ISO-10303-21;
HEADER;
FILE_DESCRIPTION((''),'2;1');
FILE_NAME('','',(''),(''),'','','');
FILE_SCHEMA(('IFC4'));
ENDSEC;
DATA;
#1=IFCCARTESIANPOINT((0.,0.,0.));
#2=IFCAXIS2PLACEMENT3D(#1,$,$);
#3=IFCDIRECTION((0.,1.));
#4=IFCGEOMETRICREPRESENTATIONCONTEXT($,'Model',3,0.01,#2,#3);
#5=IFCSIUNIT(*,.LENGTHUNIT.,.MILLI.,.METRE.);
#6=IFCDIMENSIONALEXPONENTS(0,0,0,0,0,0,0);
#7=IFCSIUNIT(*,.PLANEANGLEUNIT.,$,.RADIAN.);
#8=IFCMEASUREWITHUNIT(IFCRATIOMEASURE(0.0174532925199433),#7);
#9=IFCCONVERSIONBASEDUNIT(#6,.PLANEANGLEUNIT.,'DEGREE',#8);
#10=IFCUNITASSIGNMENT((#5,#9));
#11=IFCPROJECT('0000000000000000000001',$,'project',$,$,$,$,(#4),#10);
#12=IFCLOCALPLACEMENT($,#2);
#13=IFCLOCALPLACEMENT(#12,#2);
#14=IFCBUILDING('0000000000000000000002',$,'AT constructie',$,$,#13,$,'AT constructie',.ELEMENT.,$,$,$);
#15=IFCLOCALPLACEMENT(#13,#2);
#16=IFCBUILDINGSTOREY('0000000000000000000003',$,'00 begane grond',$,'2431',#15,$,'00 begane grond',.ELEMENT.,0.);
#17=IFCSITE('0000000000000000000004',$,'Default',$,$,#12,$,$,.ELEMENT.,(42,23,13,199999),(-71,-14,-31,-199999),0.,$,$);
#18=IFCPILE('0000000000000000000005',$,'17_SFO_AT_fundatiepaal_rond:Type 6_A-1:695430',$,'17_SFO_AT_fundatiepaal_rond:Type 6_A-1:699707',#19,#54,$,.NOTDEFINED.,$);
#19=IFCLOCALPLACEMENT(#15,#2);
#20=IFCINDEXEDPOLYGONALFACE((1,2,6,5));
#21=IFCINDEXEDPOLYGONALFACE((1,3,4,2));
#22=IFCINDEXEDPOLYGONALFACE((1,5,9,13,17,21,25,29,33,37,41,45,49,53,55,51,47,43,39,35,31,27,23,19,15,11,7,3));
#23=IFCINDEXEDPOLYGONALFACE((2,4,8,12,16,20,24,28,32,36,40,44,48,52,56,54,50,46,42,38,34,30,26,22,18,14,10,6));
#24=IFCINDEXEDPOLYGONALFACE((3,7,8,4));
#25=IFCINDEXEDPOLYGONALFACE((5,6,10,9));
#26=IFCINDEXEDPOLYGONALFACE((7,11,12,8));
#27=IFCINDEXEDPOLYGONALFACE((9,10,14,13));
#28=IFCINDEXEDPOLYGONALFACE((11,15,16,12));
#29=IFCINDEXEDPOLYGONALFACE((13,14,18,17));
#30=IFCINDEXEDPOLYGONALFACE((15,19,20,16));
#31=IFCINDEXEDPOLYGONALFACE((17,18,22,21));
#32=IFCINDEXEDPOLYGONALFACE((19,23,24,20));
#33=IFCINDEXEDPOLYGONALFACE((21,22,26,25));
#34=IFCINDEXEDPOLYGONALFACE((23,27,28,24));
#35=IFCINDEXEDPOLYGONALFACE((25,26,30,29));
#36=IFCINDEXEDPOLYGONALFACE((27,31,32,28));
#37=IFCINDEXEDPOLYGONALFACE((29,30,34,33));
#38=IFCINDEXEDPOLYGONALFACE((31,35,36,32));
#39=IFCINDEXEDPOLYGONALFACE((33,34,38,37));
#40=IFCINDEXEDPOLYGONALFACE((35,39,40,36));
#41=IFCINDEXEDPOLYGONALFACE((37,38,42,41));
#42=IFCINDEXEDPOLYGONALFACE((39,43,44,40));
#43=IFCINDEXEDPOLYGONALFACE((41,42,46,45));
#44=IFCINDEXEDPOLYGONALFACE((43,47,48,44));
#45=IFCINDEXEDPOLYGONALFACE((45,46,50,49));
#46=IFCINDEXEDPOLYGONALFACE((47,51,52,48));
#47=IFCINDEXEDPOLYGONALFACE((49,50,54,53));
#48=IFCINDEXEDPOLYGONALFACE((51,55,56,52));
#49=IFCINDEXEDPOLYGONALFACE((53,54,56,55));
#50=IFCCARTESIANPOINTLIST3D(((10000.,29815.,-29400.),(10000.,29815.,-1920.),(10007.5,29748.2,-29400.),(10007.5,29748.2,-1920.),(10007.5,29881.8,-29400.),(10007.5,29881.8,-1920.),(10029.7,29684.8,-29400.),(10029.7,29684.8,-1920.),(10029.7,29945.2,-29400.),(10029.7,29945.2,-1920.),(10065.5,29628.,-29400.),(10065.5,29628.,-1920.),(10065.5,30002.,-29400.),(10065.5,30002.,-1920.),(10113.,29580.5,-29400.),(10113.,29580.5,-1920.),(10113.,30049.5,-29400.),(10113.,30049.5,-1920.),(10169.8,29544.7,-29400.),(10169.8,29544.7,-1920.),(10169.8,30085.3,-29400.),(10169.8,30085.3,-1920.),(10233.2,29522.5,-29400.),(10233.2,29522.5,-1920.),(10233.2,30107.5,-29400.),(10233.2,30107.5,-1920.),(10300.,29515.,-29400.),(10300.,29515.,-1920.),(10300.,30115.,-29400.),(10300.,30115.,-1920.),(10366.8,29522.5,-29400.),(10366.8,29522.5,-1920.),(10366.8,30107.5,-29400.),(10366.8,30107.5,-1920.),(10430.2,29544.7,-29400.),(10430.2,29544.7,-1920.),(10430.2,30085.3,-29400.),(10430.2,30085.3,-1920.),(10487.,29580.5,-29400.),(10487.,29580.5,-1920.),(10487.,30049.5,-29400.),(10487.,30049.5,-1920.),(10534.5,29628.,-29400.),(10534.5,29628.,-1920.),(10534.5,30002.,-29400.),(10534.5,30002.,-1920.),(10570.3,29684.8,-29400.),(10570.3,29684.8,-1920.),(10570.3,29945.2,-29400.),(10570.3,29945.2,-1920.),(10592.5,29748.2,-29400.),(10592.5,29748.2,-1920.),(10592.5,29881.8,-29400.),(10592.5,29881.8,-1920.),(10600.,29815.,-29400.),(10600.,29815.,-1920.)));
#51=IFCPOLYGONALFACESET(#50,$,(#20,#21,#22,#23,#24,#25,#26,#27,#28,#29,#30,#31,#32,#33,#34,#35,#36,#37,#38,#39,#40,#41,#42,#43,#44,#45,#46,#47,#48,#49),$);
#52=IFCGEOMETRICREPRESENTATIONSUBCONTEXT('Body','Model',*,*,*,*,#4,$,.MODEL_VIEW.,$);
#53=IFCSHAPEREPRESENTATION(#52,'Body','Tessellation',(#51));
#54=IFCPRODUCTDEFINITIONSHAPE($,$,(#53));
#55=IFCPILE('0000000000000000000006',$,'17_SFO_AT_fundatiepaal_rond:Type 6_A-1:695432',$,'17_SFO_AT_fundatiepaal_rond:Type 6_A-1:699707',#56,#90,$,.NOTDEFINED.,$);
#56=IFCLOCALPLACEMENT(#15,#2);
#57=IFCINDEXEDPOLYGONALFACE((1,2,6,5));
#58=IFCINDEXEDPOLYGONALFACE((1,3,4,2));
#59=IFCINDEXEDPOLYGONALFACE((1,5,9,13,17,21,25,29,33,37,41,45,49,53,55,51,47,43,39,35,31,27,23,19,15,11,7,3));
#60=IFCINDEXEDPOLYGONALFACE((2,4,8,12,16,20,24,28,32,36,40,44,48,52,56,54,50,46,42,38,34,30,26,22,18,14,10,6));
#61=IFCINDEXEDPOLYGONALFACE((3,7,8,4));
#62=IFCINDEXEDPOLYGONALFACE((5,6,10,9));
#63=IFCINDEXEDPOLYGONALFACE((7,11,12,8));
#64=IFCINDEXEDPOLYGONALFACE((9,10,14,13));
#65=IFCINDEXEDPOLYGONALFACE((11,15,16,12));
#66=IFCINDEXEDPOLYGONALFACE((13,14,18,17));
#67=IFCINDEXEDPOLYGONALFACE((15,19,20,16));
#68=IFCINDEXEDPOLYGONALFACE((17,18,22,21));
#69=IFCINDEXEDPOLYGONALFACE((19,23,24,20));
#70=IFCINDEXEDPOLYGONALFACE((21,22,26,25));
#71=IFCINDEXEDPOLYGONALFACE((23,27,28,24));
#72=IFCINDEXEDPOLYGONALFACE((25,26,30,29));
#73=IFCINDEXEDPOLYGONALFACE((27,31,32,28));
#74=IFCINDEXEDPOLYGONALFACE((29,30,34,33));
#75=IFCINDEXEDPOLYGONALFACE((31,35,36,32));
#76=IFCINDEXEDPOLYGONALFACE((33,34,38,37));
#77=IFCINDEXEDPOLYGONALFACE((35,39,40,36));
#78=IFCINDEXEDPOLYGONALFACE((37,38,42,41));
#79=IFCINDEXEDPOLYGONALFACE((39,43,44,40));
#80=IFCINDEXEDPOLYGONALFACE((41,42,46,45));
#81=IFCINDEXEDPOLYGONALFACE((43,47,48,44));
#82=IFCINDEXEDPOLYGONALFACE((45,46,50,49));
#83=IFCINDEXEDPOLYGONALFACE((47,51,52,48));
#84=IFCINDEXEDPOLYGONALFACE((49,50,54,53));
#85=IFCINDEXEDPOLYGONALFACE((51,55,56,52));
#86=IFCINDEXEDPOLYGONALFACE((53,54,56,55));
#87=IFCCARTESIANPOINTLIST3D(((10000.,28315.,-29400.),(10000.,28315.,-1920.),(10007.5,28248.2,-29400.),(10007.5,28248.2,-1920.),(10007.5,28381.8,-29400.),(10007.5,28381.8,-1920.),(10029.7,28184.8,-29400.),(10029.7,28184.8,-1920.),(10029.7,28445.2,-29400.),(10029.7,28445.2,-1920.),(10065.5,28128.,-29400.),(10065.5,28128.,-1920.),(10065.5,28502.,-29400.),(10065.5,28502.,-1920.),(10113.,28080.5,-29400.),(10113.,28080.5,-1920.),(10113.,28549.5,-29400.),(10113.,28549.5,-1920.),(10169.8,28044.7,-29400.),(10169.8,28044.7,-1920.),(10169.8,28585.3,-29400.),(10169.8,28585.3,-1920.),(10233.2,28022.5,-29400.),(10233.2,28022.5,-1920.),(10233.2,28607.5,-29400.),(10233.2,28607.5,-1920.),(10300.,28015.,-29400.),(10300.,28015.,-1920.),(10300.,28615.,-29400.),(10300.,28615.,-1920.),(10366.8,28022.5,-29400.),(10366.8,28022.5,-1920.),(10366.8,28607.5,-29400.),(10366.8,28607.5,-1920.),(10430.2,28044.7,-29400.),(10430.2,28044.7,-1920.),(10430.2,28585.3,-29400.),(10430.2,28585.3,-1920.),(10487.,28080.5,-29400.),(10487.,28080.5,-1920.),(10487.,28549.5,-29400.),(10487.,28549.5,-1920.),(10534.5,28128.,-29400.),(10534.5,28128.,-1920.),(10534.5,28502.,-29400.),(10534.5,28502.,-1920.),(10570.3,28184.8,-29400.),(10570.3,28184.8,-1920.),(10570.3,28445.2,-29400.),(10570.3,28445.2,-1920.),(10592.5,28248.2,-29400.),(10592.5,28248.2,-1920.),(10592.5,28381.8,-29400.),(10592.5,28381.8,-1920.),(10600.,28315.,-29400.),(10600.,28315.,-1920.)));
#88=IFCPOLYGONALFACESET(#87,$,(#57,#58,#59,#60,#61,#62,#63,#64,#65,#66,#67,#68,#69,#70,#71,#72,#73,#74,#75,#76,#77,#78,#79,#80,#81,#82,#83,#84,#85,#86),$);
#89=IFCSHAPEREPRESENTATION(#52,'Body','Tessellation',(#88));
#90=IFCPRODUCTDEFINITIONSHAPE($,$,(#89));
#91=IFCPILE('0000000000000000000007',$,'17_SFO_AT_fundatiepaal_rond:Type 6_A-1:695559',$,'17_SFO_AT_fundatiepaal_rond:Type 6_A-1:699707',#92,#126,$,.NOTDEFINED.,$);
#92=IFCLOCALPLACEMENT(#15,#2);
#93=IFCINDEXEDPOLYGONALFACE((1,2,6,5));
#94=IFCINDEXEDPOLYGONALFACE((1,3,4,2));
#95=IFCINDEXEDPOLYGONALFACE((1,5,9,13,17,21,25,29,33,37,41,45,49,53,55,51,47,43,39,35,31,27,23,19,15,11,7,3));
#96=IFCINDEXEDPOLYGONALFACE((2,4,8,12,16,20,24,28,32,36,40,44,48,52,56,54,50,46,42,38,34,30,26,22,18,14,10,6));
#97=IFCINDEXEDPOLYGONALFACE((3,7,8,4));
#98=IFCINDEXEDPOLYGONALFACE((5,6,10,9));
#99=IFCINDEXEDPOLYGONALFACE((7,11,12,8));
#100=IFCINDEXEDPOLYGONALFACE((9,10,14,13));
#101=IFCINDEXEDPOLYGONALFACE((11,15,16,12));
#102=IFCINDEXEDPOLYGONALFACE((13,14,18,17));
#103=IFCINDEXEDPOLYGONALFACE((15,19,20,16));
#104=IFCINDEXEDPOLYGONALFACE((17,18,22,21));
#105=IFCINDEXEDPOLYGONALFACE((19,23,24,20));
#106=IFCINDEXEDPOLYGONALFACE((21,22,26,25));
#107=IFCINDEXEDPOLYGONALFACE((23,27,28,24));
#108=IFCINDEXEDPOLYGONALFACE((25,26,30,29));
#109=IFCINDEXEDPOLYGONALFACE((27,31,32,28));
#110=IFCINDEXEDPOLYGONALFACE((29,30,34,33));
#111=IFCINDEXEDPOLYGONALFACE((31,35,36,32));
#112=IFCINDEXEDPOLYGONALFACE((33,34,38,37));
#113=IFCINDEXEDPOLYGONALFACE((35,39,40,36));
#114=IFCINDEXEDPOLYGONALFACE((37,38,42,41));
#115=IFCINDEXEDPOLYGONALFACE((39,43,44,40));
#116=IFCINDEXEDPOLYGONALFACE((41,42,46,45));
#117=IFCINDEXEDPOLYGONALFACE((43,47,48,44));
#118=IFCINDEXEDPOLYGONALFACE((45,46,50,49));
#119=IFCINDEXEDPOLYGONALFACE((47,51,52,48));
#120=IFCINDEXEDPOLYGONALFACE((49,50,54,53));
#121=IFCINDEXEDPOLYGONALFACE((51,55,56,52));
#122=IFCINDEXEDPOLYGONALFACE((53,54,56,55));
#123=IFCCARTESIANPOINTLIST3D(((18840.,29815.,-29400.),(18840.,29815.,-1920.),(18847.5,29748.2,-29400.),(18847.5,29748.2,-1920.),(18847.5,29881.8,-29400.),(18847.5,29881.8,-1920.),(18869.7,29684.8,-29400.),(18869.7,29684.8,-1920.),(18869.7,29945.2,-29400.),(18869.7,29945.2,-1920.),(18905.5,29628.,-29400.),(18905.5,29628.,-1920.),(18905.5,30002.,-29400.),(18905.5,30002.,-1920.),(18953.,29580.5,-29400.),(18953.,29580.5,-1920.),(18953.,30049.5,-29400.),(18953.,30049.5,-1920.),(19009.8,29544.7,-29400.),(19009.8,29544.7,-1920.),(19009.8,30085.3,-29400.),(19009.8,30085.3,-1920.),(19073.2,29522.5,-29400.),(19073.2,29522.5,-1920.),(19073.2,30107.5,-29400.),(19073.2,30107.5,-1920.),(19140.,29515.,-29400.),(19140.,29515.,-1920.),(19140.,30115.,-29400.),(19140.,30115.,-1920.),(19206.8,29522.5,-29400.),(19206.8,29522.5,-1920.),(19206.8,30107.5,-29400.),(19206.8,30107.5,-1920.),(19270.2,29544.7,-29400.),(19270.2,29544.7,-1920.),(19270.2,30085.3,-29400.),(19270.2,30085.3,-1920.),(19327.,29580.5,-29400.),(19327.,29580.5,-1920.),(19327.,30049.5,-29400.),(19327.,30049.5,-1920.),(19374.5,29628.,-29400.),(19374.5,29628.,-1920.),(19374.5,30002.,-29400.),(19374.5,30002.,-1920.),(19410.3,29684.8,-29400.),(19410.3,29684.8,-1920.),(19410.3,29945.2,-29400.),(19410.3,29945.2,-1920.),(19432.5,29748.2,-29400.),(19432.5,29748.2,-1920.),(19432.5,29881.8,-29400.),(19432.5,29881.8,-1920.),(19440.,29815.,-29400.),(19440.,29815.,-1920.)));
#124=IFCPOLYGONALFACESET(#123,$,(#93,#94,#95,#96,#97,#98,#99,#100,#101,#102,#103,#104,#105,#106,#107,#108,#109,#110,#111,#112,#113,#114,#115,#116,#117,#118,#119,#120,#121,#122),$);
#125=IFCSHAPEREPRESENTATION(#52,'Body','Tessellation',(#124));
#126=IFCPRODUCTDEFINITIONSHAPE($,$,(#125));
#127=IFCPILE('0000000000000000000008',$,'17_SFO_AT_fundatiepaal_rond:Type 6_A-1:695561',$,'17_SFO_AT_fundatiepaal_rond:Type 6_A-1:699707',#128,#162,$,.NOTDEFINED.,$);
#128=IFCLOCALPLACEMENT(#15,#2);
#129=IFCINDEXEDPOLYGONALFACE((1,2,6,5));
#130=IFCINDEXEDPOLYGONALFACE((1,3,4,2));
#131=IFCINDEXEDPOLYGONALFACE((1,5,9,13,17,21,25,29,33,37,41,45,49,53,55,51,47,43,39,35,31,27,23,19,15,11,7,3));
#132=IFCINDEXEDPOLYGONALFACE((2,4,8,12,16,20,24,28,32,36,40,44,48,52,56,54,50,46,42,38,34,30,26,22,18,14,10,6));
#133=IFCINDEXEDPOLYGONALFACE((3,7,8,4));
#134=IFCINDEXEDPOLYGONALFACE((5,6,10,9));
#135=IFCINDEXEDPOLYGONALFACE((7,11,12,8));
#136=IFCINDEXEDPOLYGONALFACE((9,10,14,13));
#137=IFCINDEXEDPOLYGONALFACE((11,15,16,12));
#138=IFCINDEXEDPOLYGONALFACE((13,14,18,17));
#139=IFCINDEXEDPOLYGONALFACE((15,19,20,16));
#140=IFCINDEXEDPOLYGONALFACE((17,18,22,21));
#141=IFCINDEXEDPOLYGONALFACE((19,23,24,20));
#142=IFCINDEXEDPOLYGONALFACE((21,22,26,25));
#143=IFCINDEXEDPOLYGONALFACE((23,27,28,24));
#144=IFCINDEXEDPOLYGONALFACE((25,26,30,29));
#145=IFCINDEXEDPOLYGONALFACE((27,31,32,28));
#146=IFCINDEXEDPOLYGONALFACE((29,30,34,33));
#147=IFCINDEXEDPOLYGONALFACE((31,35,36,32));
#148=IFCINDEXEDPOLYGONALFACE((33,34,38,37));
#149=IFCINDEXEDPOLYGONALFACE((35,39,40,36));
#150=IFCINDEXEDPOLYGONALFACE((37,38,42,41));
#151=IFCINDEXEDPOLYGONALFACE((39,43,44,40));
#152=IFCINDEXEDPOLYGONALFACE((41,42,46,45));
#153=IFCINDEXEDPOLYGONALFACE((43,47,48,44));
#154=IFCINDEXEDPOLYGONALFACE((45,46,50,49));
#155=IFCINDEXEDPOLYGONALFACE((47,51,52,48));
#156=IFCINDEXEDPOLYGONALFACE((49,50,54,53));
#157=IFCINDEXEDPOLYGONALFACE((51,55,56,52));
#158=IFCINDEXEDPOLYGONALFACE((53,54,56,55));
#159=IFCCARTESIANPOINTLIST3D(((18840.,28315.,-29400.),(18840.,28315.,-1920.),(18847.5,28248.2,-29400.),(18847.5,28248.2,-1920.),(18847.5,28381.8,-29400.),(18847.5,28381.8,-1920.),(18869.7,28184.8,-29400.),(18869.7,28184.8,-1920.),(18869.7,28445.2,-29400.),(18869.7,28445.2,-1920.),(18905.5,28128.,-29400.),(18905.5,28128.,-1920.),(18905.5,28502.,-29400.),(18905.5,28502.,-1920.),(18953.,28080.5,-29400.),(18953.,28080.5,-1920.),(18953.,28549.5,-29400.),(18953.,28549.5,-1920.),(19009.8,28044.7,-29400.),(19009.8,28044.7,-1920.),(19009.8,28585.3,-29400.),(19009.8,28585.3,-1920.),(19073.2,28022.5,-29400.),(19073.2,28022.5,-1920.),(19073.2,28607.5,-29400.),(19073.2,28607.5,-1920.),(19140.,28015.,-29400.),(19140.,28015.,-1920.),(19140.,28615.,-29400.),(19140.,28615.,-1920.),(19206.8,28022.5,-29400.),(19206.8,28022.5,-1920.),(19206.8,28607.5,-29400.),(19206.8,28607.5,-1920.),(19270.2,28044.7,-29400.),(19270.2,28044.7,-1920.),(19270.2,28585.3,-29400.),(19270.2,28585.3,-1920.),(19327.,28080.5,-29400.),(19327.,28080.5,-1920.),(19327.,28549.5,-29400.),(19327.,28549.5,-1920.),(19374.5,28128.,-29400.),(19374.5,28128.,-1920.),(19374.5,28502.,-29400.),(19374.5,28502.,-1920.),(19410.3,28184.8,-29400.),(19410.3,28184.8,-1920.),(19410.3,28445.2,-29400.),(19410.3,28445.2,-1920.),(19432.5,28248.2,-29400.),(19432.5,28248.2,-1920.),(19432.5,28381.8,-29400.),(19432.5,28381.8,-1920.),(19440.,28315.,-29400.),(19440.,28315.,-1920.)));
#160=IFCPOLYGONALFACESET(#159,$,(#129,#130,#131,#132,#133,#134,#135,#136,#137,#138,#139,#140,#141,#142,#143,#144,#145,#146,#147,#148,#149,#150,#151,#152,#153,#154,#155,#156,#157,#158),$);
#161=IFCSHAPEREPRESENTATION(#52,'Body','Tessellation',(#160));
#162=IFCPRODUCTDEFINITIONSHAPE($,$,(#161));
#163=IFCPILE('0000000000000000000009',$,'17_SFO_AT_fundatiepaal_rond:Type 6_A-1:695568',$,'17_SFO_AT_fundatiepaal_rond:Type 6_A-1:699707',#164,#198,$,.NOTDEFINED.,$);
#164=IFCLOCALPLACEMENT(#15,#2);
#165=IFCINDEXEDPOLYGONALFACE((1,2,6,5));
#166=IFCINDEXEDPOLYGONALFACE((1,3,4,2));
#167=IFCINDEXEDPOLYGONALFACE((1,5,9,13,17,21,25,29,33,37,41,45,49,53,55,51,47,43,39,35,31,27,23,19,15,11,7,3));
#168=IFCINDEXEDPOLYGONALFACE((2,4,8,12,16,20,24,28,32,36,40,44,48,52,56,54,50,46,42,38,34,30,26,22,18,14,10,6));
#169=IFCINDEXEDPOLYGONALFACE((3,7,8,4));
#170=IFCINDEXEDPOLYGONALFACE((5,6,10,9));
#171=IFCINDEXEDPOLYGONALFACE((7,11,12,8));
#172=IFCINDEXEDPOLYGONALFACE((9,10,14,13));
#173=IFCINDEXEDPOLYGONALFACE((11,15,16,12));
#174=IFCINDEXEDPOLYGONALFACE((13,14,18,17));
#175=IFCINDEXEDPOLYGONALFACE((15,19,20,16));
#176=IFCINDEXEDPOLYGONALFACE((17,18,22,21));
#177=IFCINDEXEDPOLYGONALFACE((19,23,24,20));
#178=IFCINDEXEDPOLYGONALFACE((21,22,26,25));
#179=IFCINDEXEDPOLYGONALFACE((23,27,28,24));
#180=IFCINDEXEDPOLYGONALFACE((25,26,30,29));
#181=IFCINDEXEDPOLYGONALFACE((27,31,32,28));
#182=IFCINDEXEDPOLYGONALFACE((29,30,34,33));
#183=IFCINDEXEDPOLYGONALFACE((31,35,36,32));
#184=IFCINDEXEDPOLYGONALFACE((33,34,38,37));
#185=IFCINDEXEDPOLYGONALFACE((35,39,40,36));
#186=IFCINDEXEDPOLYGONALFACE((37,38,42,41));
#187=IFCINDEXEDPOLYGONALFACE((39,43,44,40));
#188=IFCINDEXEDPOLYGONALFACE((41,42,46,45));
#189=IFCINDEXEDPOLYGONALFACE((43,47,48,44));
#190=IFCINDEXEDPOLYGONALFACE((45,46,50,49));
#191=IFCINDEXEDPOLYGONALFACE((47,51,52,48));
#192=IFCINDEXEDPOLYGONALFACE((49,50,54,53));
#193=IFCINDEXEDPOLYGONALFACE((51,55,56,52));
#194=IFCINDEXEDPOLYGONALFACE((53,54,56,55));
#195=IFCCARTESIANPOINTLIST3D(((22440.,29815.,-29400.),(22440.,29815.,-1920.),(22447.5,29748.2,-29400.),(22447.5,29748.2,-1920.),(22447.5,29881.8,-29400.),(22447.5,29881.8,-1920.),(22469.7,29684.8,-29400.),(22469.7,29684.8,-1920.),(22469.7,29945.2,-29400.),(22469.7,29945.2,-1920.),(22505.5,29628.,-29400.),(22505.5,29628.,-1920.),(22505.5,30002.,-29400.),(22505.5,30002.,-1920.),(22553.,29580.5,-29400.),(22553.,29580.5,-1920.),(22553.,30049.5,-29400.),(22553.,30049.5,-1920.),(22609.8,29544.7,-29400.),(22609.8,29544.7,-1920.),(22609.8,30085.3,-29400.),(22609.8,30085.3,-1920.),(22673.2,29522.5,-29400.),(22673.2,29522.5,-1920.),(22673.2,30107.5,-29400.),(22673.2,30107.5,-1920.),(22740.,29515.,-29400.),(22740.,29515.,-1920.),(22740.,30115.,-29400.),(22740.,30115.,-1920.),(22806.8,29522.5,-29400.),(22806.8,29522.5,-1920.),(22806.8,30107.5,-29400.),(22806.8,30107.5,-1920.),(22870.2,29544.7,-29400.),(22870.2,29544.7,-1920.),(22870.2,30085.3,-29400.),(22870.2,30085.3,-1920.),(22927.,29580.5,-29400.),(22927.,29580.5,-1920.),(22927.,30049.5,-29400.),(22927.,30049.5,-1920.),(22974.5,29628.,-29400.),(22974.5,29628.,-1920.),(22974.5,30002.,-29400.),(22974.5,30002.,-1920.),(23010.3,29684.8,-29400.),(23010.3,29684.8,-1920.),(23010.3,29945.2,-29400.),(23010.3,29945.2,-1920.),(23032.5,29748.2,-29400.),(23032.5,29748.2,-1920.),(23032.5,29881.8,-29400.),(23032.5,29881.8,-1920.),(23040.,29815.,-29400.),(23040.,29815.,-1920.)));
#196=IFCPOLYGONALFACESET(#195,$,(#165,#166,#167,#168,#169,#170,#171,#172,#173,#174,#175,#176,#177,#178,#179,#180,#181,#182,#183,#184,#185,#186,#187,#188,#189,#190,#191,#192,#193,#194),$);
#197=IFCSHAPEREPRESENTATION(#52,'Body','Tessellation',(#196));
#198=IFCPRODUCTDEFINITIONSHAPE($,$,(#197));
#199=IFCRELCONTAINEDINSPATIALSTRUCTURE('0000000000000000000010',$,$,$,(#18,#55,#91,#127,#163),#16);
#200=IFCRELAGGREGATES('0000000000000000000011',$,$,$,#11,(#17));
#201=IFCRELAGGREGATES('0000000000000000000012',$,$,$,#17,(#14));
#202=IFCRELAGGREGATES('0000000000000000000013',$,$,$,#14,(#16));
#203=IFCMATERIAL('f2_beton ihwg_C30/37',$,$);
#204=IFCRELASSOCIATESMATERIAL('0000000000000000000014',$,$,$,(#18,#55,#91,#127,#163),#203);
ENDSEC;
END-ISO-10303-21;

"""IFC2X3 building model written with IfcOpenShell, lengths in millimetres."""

from ifc_helpers import new_model, entity, si_unit, converted_unit, direction, frame, origin, origin_2d_with_axis, place, context, subcontext, project, spatial, circle, extrude, material, element, save


model = new_model("IFC2X3")

# Units and contexts
model_context = context("Model", 3, precision=0.01, world=origin(), true_north=direction((0.0, 1.0)))
body_context = subcontext(model_context, "Body", "Model", "MODEL_VIEW")
ifc_project = project(units=[si_unit("LENGTHUNIT", "METRE", prefix="MILLI"), converted_unit("PLANEANGLEUNIT", "DEGREE", entity("IfcRatioMeasure", 0.0174532925199433), si_unit("PLANEANGLEUNIT", "RADIAN"), dimensions=[0, 0, 0, 0, 0, 0, 0])], contexts=[model_context])

# Site, building, storey
site_placement = place(None, origin())
site = spatial("IfcSite", under=ifc_project, at=site_placement, Name="Default", CompositionType="ELEMENT", RefLatitude=(42, 23, 13, 199999), RefLongitude=(-71, -14, -31, -199999), RefElevation=0.0)
building_placement = place(site_placement, origin())
building = spatial("IfcBuilding", under=site, at=building_placement, Name="AT constructie", LongName="AT constructie", CompositionType="ELEMENT")
storey_placement = place(building_placement, origin())
storey = spatial("IfcBuildingStorey", under=building, at=storey_placement, Name="00 begane grond", ObjectType="2431", LongName="00 begane grond", CompositionType="ELEMENT", Elevation=0.0)

# Piles
ifc_material = material(Name="f2_beton ihwg_C30/37")
pile_1_placement = place(storey_placement, origin())
element("IfcPile", 1, at=pile_1_placement, inside=storey, material=ifc_material, Name="17_SFO_AT_fundatiepaal_rond:Type 6_A-1:695430", ObjectType="17_SFO_AT_fundatiepaal_rond:Type 6_A-1:699707", PredefinedType="NOTDEFINED", context=body_context, shape_type="SweptSolid", body=[
    extrude(circle(Radius=300.0, at=origin_2d_with_axis()), frame((10300.0, 29815.0, -29400.0)), (0.0, 0.0, 1.0), 27480.0),
])
pile_2_placement = place(storey_placement, origin())
element("IfcPile", 2, at=pile_2_placement, inside=storey, material=ifc_material, Name="17_SFO_AT_fundatiepaal_rond:Type 6_A-1:695432", ObjectType="17_SFO_AT_fundatiepaal_rond:Type 6_A-1:699707", PredefinedType="NOTDEFINED", context=body_context, shape_type="SweptSolid", body=[
    extrude(circle(Radius=300.0, at=origin_2d_with_axis()), frame((10300.0, 28315.0, -29400.0)), (0.0, 0.0, 1.0), 27480.0),
])
pile_3_placement = place(storey_placement, origin())
element("IfcPile", 3, at=pile_3_placement, inside=storey, material=ifc_material, Name="17_SFO_AT_fundatiepaal_rond:Type 6_A-1:695559", ObjectType="17_SFO_AT_fundatiepaal_rond:Type 6_A-1:699707", PredefinedType="NOTDEFINED", context=body_context, shape_type="SweptSolid", body=[
    extrude(circle(Radius=300.0, at=origin_2d_with_axis()), frame((19140.0, 29815.0, -29400.0)), (0.0, 0.0, 1.0), 27480.0),
])
pile_4_placement = place(storey_placement, origin())
element("IfcPile", 4, at=pile_4_placement, inside=storey, material=ifc_material, Name="17_SFO_AT_fundatiepaal_rond:Type 6_A-1:695561", ObjectType="17_SFO_AT_fundatiepaal_rond:Type 6_A-1:699707", PredefinedType="NOTDEFINED", context=body_context, shape_type="SweptSolid", body=[
    extrude(circle(Radius=300.0, at=origin_2d_with_axis()), frame((19140.0, 28315.0, -29400.0)), (0.0, 0.0, 1.0), 27480.0),
])

# Pile
pile_5_placement = place(storey_placement, origin())
element("IfcPile", 5, at=pile_5_placement, inside=storey, material=ifc_material, Name="17_SFO_AT_fundatiepaal_rond:Type 6_A-1:695568", ObjectType="17_SFO_AT_fundatiepaal_rond:Type 6_A-1:699707", PredefinedType="NOTDEFINED", context=body_context, shape_type="SweptSolid", body=[
    extrude(circle(Radius=300.0, at=origin_2d_with_axis()), frame((22740.0, 29815.0, -29400.0)), (0.0, 0.0, 1.0), 27480.0),
])

save(model, "model.ifc")
